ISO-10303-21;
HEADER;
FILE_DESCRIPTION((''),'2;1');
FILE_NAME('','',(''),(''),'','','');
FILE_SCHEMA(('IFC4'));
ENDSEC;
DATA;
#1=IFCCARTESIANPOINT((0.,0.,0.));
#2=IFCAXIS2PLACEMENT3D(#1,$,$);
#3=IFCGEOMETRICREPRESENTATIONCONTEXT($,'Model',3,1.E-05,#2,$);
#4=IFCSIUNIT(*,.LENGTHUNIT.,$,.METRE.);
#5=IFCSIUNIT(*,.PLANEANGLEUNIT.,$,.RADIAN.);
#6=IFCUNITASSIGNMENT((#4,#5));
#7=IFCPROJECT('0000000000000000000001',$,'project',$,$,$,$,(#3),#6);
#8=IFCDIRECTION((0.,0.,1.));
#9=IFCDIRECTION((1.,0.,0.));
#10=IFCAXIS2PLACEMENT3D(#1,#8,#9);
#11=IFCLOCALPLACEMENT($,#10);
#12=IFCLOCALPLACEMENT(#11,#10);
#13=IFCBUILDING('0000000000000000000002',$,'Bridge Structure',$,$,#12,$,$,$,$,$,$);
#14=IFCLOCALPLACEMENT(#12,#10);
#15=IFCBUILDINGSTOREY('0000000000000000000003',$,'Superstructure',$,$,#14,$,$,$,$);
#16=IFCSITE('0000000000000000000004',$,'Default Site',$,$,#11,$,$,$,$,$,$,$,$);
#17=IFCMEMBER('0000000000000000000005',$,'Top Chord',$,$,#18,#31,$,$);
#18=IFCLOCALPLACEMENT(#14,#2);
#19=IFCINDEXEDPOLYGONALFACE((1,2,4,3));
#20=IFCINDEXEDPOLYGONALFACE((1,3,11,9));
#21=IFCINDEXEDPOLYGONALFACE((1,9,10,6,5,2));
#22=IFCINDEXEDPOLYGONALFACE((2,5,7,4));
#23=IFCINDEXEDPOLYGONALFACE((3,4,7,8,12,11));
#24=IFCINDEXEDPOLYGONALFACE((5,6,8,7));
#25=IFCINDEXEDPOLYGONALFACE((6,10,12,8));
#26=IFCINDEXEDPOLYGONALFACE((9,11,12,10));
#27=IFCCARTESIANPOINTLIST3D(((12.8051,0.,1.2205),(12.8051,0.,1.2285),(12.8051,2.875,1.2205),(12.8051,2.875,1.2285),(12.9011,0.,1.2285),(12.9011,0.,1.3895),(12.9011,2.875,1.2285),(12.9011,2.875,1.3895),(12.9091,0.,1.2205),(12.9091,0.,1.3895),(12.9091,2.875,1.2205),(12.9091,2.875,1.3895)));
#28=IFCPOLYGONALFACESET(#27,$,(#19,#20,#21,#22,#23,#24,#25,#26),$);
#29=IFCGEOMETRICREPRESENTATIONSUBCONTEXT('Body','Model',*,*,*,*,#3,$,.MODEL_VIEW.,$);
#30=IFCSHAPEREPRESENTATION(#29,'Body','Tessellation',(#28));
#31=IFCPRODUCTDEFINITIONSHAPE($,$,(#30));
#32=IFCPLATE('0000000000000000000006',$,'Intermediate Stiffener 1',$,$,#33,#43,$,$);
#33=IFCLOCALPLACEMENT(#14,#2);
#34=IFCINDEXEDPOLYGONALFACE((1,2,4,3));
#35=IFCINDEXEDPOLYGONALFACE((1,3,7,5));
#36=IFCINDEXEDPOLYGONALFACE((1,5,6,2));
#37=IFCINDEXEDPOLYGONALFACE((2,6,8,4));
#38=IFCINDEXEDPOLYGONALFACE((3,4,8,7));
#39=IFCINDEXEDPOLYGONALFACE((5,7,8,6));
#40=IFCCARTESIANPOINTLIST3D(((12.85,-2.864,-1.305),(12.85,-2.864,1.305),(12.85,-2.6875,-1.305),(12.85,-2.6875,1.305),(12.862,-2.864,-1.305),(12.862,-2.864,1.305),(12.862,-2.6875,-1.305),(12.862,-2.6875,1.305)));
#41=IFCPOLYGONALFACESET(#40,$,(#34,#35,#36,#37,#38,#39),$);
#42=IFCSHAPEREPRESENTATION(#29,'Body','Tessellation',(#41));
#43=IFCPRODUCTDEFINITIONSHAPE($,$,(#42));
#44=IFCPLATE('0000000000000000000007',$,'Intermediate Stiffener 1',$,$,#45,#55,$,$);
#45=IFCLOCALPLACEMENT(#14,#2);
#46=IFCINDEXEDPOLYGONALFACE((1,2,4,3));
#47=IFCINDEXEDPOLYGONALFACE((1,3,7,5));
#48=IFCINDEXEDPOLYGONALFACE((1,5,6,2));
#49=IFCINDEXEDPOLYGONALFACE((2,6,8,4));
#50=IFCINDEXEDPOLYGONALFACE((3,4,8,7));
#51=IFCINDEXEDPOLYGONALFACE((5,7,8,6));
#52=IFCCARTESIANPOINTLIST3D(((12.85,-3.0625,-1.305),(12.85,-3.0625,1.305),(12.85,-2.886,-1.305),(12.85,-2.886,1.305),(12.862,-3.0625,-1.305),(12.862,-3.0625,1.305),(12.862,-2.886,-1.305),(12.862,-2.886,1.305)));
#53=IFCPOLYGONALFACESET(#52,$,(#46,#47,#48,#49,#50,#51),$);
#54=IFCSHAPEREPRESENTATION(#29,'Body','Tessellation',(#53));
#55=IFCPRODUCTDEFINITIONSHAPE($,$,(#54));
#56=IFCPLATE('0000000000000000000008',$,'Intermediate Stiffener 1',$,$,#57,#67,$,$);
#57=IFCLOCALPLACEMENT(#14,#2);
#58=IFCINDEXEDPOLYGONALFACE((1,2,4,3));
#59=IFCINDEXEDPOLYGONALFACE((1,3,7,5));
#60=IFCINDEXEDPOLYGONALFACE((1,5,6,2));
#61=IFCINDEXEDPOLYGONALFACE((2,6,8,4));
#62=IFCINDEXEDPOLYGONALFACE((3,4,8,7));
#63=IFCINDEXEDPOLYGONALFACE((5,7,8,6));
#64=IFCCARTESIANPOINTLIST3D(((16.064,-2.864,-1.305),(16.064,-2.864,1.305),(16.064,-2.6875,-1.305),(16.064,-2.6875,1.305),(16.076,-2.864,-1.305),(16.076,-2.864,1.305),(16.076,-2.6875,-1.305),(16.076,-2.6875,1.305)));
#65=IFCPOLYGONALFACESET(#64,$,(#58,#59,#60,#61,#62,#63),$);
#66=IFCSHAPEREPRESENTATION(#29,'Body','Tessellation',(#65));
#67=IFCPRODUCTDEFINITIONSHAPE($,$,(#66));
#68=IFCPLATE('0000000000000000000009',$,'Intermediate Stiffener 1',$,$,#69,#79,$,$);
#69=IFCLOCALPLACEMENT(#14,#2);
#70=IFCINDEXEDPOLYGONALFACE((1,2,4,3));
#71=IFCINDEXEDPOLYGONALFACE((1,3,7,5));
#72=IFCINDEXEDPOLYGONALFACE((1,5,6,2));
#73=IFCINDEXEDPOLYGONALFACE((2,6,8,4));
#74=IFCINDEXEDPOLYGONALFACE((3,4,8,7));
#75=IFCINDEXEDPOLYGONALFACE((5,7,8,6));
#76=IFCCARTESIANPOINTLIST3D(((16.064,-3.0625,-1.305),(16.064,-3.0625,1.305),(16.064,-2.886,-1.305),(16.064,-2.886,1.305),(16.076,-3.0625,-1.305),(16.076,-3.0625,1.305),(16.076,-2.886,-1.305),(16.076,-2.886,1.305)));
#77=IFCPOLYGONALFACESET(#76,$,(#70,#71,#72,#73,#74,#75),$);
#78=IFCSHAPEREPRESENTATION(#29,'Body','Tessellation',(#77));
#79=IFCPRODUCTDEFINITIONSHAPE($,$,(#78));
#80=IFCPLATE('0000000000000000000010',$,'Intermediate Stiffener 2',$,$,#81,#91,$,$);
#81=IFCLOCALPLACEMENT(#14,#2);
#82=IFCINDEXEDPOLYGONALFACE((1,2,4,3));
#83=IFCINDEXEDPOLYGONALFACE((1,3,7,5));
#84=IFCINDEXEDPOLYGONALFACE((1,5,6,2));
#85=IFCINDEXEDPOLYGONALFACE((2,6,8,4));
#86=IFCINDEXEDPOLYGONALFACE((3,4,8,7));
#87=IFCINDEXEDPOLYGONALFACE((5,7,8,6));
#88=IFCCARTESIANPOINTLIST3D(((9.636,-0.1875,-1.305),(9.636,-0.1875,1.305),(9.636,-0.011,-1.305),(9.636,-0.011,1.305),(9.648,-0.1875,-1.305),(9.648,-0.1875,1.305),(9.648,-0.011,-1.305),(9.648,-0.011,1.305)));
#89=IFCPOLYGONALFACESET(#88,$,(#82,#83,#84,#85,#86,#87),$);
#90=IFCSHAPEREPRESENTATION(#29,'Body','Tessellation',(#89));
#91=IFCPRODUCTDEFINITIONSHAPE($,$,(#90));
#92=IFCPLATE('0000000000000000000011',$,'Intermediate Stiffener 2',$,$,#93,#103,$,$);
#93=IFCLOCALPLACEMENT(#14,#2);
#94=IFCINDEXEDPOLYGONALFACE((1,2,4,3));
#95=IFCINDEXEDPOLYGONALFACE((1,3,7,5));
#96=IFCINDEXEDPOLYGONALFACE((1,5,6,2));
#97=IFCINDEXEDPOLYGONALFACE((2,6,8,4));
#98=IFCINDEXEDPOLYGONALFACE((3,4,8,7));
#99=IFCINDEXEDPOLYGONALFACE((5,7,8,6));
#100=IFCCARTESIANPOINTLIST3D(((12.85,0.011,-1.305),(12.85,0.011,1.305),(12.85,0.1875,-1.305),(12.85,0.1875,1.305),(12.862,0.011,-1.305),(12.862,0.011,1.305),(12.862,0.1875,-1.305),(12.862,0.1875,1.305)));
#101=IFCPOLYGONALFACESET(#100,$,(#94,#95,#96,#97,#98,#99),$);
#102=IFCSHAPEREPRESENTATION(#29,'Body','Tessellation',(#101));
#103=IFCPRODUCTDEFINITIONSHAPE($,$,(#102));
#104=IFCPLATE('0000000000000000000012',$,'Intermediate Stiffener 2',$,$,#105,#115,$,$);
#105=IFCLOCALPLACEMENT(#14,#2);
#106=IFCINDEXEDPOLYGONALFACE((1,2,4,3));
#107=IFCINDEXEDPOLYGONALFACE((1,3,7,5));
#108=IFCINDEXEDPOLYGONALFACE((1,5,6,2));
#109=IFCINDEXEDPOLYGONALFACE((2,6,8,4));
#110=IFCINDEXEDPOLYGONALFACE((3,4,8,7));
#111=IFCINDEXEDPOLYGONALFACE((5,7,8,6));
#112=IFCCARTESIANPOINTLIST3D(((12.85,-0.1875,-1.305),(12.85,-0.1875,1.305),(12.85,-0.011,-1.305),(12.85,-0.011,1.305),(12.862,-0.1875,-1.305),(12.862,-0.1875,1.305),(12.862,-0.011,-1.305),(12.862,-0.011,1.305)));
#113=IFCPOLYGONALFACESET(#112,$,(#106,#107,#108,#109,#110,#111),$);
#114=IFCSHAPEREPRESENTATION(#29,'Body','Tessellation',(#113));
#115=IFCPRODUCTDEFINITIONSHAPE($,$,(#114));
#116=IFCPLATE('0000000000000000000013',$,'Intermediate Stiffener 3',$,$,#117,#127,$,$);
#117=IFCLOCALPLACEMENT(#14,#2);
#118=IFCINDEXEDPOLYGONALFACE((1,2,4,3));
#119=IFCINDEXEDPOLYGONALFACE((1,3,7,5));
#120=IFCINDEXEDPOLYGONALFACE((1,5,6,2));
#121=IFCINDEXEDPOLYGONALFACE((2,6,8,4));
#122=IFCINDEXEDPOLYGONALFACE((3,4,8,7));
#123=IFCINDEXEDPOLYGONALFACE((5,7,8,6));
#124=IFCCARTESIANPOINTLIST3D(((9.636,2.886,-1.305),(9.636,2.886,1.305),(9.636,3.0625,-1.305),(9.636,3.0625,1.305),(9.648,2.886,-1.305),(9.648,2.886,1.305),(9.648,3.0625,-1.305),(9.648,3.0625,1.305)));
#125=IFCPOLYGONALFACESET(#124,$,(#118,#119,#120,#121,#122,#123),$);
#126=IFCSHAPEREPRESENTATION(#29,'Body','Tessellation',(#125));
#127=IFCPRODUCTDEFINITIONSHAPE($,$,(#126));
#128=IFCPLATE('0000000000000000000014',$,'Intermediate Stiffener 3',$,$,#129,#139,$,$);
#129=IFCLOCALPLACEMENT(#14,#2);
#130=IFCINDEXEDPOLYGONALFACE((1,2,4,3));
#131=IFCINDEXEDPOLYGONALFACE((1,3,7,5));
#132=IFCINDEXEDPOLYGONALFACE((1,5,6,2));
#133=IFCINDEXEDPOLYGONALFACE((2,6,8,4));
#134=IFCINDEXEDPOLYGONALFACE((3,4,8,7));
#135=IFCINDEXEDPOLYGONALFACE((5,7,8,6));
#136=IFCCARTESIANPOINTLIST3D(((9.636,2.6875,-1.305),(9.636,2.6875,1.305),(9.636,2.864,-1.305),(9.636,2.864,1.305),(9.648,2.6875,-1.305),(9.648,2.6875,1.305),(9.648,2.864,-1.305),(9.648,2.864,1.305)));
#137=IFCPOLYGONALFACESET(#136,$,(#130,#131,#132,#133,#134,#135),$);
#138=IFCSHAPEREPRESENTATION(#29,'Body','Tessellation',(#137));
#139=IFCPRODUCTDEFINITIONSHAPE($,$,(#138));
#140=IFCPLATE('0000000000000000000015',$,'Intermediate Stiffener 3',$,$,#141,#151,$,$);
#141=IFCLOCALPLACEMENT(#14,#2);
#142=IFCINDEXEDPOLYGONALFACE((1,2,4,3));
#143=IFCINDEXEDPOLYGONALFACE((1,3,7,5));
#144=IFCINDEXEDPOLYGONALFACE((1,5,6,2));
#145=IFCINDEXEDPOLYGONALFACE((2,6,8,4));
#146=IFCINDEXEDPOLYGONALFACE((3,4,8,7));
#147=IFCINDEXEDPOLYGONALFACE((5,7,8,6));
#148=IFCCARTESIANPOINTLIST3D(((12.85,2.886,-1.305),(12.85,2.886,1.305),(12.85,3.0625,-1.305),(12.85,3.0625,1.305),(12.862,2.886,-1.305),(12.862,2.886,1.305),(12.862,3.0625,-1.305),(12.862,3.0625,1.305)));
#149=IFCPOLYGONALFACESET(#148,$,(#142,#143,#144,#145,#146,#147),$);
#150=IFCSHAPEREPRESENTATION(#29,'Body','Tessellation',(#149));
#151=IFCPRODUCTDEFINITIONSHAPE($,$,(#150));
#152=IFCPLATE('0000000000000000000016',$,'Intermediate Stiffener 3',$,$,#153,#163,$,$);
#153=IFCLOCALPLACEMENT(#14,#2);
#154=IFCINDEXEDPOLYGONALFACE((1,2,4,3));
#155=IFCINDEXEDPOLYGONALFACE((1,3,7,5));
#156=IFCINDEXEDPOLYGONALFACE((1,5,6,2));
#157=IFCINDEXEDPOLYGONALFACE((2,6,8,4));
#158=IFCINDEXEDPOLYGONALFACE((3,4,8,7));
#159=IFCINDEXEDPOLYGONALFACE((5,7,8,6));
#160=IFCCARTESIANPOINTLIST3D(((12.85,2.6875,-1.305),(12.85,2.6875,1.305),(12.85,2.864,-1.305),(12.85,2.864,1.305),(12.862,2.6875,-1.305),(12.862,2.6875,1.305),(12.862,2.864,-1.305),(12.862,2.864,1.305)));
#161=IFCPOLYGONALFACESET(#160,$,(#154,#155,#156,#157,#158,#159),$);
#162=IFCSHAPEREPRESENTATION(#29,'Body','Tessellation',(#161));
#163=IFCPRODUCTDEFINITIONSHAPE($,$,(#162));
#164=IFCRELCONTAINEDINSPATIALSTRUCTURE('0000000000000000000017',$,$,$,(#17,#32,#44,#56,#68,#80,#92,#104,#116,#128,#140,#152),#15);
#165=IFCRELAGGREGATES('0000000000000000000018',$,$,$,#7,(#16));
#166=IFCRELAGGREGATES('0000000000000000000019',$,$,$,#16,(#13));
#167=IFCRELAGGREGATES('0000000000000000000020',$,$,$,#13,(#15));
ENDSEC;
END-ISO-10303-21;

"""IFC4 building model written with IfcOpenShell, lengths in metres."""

from ifc_helpers import new_model, si_unit, frame, origin, origin_with_axes, origin_2d_with_axis, place, context, subcontext, project, spatial, rectangle, l_section, extrude, element, save


model = new_model("IFC4")

# Units and contexts
model_context = context("Model", 3, precision=1e-05, world=origin())
body_context = subcontext(model_context, "Body", "Model", "MODEL_VIEW")
ifc_project = project(units=[si_unit("LENGTHUNIT", "METRE"), si_unit("PLANEANGLEUNIT", "RADIAN")], contexts=[model_context])

# Site, building, storey
site_placement = place(None, origin_with_axes())
site = spatial("IfcSite", under=ifc_project, at=site_placement, Name="Default Site")
building_placement = place(site_placement, origin_with_axes())
building = spatial("IfcBuilding", under=site, at=building_placement, Name="Bridge Structure")
storey_placement = place(building_placement, origin_with_axes())
storey = spatial("IfcBuildingStorey", under=building, at=storey_placement, Name="Superstructure")

# Member
for number, where, z_axis, x_axis, name in (
    (1, (12.8571, 0.0, 1.305), (0.0, 1.0, 0.0), (-1.0, 0.0, 0.0), "Top Chord"),
):
    element("IfcMember", number, at=place(storey_placement, frame(where, z_axis=z_axis, x_axis=x_axis)), inside=storey, Name=name, context=body_context, shape_type="SweptSolid", body=[
        extrude(l_section(Depth=0.169, Width=0.104, Thickness=0.008, at=origin_2d_with_axis()), origin_with_axes(), (0.0, 0.0, 1.0), 2.875),
    ])

# Plates
for number, where, z_axis, x_axis, name in (
    (2, (12.856, -2.7757, -1.305), (0.0, 0.0, 1.0), (1.0, 0.0, 0.0), "Intermediate Stiffener 1"),
    (3, (12.856, -2.9743, -1.305), (0.0, 0.0, 1.0), (1.0, 0.0, 0.0), "Intermediate Stiffener 1"),
    (4, (16.07, -2.7757, -1.305), (0.0, 0.0, 1.0), (1.0, 0.0, 0.0), "Intermediate Stiffener 1"),
    (5, (16.07, -2.9743, -1.305), (0.0, 0.0, 1.0), (1.0, 0.0, 0.0), "Intermediate Stiffener 1"),
    (6, (9.642, -0.0993, -1.305), (0.0, 0.0, 1.0), (1.0, 0.0, 0.0), "Intermediate Stiffener 2"),
    (7, (12.856, 0.0993, -1.305), (0.0, 0.0, 1.0), (1.0, 0.0, 0.0), "Intermediate Stiffener 2"),
    (8, (12.856, -0.0993, -1.305), (0.0, 0.0, 1.0), (1.0, 0.0, 0.0), "Intermediate Stiffener 2"),
    (9, (9.642, 2.9743, -1.305), (0.0, 0.0, 1.0), (1.0, 0.0, 0.0), "Intermediate Stiffener 3"),
    (10, (9.642, 2.7757, -1.305), (0.0, 0.0, 1.0), (1.0, 0.0, 0.0), "Intermediate Stiffener 3"),
    (11, (12.856, 2.9743, -1.305), (0.0, 0.0, 1.0), (1.0, 0.0, 0.0), "Intermediate Stiffener 3"),
    (12, (12.856, 2.7757, -1.305), (0.0, 0.0, 1.0), (1.0, 0.0, 0.0), "Intermediate Stiffener 3"),
):
    element("IfcPlate", number, at=place(storey_placement, frame(where, z_axis=z_axis, x_axis=x_axis)), inside=storey, Name=name, context=body_context, shape_type="SweptSolid", body=[
        extrude(rectangle(XDim=0.012, YDim=0.1765, at=origin_2d_with_axis()), origin_with_axes(), (0.0, 0.0, 1.0), 2.61),
    ])

save(model, "model.ifc")
